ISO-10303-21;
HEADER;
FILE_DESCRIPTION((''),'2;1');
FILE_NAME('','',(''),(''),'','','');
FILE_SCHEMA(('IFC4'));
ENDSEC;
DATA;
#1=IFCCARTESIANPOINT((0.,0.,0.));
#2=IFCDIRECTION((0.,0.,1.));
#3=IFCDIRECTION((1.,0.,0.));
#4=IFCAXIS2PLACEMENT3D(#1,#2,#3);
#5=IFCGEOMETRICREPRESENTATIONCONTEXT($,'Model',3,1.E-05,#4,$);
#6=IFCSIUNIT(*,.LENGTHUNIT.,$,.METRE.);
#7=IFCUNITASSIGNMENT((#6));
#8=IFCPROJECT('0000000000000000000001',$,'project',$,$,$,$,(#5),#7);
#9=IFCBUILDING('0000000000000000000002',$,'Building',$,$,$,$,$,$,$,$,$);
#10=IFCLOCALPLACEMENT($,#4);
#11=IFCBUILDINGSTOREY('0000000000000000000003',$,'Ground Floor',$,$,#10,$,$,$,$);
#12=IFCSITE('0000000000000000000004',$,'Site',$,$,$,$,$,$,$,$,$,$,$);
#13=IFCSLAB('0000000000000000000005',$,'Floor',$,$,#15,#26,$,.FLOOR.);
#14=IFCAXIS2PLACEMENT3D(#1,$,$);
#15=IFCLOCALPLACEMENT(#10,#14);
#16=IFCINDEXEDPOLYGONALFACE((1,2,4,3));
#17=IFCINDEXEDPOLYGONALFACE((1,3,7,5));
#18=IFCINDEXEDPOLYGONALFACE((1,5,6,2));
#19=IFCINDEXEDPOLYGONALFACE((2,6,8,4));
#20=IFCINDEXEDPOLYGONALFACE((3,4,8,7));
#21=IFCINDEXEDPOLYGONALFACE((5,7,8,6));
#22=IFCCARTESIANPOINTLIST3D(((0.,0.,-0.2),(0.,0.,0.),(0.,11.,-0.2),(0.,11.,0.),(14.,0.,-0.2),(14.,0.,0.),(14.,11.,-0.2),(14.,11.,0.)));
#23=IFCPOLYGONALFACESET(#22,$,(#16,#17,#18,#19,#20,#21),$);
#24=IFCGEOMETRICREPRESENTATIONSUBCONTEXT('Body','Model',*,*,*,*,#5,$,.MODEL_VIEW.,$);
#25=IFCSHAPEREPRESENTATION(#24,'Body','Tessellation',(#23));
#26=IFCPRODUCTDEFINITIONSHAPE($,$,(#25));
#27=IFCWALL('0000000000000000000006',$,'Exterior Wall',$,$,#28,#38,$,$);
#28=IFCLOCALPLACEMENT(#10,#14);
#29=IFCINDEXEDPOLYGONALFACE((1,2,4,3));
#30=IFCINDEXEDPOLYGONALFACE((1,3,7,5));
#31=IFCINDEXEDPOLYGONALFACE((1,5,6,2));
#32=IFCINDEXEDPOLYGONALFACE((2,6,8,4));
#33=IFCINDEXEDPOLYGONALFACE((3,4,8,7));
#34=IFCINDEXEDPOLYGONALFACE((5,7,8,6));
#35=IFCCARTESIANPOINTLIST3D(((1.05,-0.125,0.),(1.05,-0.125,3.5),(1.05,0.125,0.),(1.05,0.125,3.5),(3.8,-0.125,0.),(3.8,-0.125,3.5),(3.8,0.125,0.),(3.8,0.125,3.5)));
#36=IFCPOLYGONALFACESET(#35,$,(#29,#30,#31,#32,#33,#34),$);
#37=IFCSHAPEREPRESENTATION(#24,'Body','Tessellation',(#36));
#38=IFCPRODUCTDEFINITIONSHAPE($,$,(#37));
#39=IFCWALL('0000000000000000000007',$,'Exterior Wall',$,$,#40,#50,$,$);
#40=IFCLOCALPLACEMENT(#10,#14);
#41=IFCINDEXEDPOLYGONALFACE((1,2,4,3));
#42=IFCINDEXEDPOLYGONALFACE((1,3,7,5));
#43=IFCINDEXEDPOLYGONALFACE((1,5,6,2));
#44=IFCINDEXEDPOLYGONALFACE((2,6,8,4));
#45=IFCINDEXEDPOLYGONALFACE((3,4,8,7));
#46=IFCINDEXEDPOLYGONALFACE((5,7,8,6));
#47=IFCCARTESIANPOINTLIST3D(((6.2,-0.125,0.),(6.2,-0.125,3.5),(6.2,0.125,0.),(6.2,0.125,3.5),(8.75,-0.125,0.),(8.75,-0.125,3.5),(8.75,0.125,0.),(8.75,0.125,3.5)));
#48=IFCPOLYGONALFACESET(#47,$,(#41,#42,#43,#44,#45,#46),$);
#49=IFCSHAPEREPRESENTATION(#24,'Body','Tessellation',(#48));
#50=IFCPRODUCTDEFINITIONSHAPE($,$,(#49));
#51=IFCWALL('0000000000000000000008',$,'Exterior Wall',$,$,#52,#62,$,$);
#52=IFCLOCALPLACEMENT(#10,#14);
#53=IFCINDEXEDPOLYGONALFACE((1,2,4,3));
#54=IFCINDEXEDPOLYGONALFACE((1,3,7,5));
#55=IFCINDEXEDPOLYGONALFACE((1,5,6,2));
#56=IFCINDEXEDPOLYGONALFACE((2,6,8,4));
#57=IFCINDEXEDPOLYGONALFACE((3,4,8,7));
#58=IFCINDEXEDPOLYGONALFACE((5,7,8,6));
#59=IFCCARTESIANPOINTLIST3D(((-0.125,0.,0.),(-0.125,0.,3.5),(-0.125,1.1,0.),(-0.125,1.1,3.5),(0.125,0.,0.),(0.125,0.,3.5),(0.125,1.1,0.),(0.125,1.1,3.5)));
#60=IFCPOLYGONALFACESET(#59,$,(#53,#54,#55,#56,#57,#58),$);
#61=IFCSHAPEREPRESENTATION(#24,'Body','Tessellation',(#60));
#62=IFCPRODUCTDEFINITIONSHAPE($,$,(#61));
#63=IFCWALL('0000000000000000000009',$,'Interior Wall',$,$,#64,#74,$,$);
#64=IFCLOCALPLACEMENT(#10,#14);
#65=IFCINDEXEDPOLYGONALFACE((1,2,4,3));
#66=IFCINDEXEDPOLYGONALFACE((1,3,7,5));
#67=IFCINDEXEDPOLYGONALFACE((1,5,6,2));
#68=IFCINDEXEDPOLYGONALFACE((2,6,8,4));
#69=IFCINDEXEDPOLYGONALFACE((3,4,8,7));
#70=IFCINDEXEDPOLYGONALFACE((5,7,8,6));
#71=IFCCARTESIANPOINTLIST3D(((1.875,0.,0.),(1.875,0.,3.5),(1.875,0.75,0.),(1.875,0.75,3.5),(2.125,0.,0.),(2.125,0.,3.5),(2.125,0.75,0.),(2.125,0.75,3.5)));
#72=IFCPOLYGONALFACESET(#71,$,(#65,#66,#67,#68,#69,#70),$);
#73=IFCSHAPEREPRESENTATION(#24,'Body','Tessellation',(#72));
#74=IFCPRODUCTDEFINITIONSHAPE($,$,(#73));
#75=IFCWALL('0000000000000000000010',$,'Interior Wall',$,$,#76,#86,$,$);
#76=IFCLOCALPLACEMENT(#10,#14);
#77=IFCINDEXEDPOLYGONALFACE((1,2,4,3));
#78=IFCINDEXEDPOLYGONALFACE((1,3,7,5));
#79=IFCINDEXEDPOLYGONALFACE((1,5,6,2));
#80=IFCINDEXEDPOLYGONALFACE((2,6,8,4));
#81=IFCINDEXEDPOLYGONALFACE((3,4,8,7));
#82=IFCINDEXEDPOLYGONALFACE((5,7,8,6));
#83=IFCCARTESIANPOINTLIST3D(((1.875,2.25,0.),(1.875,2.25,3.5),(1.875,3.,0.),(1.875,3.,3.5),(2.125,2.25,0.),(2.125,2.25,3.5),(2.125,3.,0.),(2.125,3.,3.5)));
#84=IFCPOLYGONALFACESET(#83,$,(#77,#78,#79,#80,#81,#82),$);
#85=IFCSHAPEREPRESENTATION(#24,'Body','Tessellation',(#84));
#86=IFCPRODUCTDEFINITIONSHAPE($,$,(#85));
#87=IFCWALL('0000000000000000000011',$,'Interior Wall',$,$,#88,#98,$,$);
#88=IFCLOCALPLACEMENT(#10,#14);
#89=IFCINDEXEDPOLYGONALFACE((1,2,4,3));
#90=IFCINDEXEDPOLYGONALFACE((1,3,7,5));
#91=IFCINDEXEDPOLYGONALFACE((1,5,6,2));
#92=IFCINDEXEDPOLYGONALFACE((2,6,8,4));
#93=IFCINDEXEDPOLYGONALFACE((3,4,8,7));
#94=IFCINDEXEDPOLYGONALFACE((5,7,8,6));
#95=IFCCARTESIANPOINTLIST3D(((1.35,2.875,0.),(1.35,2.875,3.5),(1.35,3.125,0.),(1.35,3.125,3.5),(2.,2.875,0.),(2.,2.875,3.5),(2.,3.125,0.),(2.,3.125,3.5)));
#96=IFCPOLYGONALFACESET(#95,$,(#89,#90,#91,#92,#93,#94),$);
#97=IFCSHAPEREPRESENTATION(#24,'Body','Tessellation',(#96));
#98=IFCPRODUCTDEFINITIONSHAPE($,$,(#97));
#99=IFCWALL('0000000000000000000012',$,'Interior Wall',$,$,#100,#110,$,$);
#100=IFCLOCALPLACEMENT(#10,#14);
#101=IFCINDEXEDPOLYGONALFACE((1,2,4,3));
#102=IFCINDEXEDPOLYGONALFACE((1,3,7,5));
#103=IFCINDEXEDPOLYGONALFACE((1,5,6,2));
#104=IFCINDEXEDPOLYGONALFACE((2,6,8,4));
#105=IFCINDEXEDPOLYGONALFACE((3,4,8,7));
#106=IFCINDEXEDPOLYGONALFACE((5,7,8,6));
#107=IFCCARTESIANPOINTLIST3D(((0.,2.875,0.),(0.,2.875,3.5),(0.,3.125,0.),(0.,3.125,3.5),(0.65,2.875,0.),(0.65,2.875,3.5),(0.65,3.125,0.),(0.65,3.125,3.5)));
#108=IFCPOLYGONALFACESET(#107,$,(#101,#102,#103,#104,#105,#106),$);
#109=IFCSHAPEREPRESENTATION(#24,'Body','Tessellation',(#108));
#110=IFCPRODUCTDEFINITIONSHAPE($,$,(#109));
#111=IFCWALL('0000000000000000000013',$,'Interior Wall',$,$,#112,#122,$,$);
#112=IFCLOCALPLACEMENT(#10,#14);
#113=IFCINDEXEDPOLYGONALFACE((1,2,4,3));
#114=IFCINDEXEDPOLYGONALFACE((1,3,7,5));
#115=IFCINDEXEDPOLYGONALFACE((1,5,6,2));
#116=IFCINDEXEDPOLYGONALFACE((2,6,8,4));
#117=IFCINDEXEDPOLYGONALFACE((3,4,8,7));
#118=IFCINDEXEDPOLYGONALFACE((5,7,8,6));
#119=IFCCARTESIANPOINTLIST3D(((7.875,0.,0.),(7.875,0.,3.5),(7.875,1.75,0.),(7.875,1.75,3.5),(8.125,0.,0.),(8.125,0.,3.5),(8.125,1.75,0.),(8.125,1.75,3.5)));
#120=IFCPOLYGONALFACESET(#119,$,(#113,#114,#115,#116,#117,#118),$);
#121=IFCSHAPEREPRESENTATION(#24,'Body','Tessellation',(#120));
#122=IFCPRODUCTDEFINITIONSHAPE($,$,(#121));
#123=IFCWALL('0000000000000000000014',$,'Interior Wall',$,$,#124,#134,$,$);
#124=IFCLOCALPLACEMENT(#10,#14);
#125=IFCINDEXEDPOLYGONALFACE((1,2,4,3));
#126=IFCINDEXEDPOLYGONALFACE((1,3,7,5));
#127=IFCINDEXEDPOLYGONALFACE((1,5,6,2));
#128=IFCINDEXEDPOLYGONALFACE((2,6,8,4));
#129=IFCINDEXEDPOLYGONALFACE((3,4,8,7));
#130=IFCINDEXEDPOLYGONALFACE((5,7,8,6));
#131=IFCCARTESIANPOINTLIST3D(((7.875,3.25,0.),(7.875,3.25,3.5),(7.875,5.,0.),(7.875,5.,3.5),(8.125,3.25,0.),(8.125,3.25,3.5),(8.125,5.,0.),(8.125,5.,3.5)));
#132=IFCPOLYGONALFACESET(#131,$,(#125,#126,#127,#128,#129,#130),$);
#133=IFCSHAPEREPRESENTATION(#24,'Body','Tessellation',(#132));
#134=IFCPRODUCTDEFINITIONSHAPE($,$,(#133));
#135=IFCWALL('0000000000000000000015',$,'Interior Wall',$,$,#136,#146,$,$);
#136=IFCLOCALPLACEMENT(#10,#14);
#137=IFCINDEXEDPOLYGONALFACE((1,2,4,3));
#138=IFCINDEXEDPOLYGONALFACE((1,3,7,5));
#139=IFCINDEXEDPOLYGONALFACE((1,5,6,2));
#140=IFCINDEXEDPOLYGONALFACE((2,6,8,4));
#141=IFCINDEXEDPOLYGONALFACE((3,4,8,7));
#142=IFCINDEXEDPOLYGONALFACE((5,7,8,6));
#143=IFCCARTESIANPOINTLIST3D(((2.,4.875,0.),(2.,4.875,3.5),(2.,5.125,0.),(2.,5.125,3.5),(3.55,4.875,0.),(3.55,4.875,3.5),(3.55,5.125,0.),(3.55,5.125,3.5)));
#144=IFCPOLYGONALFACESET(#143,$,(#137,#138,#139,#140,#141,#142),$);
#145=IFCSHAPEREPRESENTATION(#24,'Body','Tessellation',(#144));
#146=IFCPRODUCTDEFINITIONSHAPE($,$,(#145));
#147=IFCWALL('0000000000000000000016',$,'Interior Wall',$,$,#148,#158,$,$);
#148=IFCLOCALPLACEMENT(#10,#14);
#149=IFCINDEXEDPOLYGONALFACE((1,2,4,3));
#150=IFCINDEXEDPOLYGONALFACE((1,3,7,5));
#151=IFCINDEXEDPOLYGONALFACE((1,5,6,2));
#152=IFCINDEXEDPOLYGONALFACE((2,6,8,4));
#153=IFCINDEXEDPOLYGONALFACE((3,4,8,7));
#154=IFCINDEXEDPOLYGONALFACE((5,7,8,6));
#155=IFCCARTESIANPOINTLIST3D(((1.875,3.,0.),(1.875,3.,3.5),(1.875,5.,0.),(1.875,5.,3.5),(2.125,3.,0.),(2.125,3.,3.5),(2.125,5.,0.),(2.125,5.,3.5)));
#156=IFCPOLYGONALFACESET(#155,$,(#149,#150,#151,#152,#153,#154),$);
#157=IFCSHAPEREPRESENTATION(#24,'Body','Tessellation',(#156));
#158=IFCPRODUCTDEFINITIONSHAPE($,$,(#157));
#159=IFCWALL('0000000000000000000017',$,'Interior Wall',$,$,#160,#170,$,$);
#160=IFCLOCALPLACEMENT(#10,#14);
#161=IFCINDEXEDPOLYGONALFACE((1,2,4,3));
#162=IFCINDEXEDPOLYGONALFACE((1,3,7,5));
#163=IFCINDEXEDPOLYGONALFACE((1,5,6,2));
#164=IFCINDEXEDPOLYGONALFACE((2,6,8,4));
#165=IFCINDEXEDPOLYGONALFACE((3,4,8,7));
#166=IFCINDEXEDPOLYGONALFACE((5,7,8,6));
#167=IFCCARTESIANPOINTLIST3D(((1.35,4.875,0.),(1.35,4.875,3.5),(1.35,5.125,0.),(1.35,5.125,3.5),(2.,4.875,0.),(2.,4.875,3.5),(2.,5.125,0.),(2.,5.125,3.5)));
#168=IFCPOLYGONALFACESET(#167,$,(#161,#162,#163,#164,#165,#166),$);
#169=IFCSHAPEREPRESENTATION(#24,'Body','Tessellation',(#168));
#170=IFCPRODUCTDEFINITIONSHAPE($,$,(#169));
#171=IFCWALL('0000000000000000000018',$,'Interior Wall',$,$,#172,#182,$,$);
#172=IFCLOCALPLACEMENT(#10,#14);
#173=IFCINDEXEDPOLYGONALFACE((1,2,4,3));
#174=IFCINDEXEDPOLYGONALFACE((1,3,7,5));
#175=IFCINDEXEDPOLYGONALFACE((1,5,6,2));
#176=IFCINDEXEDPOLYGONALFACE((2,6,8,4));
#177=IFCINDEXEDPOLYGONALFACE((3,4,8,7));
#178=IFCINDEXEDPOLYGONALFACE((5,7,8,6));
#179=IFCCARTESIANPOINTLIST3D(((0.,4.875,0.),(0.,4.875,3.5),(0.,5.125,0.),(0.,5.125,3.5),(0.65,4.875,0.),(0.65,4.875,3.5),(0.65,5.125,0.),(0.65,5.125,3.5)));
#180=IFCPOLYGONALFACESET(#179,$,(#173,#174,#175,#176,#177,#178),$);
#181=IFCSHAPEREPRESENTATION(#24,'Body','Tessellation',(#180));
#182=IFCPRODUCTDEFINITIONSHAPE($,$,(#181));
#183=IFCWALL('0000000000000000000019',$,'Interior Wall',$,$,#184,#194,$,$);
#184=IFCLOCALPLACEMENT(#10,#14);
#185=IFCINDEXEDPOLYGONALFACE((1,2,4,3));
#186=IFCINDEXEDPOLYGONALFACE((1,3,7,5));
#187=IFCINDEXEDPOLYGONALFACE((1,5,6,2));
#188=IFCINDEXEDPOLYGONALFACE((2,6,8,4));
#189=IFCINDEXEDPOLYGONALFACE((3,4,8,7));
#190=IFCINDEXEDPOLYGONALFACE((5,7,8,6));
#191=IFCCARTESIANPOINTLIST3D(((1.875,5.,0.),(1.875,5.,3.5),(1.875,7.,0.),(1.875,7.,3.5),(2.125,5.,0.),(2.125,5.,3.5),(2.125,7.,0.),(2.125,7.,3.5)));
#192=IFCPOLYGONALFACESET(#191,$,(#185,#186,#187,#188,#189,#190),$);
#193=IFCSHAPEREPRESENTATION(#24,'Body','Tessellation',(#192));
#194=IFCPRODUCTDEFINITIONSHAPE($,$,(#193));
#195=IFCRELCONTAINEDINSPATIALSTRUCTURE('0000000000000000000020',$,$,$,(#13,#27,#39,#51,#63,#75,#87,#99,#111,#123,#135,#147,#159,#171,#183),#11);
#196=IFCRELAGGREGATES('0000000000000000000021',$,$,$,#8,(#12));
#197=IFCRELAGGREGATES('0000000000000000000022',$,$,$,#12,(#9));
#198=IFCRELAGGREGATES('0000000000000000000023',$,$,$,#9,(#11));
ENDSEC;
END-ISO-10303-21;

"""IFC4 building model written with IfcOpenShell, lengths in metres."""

from ifc_helpers import new_model, si_unit, frame, origin_with_axes, place, context, subcontext, project, spatial, indexed_curve, outline, extrude, element, save


model = new_model("IFC4")

# Units and contexts
model_context = context("Model", 3, precision=1e-05, world=origin_with_axes())
body_context = subcontext(model_context, "Body", "Model", "MODEL_VIEW")
ifc_project = project(units=[si_unit("LENGTHUNIT", "METRE")], contexts=[model_context])

# Site, building, storey
site = spatial("IfcSite", under=ifc_project, Name="Site")
building = spatial("IfcBuilding", under=site, Name="Building")
storey_placement = place(None, origin_with_axes())
storey = spatial("IfcBuildingStorey", under=building, at=storey_placement, Name="Ground Floor")

# Slab
slab_placement = place(storey_placement, frame((0.0, 0.0, -0.2), z_axis=(0.0, 0.0, 1.0), x_axis=(1.0, 0.0, 0.0)))
element("IfcSlab", 1, at=slab_placement, inside=storey, Name="Floor", PredefinedType="FLOOR", context=body_context, shape_type="SweptSolid", body=[
    extrude(outline(indexed_curve([(0.0, 0.0), (14.0, 0.0), (14.0, 11.0), (0.0, 11.0)])), None, (0.0, 0.0, 1.0), 0.2),
])

# Walls
wall_1_placement = place(storey_placement, frame((1.05, 0.0, 0.0), z_axis=(0.0, 0.0, 1.0), x_axis=(1.0, 0.0, 0.0)))
element("IfcWall", 2, at=wall_1_placement, inside=storey, Name="Exterior Wall", context=body_context, shape_type="SweptSolid", body=[
    extrude(outline(indexed_curve([(0.0, 0.0), (0.0, 0.25), (2.75, 0.25), (2.75, 0.0), (0.0, 0.0)], self_intersect=False)), frame((0.0, -0.125, 0.0), z_axis=(0.0, 0.0, 1.0), x_axis=(1.0, 0.0, 0.0)), (0.0, 0.0, 1.0), 3.5),
])
wall_2_placement = place(storey_placement, frame((6.2, 0.0, 0.0), z_axis=(0.0, 0.0, 1.0), x_axis=(1.0, 0.0, 0.0)))
element("IfcWall", 3, at=wall_2_placement, inside=storey, Name="Exterior Wall", context=body_context, shape_type="SweptSolid", body=[
    extrude(outline(indexed_curve([(0.0, 0.0), (0.0, 0.25), (2.55, 0.25), (2.55, 0.0), (0.0, 0.0)], self_intersect=False)), frame((0.0, -0.125, 0.0), z_axis=(0.0, 0.0, 1.0), x_axis=(1.0, 0.0, 0.0)), (0.0, 0.0, 1.0), 3.5),
])
wall_3_placement = place(storey_placement, frame((0.0, 1.1, 0.0), z_axis=(0.0, 0.0, 1.0), x_axis=(0.0, -1.0, 0.0)))
element("IfcWall", 4, at=wall_3_placement, inside=storey, Name="Exterior Wall", context=body_context, shape_type="SweptSolid", body=[
    extrude(outline(indexed_curve([(0.0, 0.0), (0.0, 0.25), (1.1, 0.25), (1.1, 0.0), (0.0, 0.0)], self_intersect=False)), frame((0.0, -0.125, 0.0), z_axis=(0.0, 0.0, 1.0), x_axis=(1.0, 0.0, 0.0)), (0.0, 0.0, 1.0), 3.5),
])
for number, where, z_axis, x_axis, name in (
    (5, (2.0, 0.0, 0.0), (0.0, 0.0, 1.0), (0.0, 1.0, 0.0), "Interior Wall"),
    (6, (2.0, 2.25, 0.0), (0.0, 0.0, 1.0), (0.0, 1.0, 0.0), "Interior Wall"),
):
    element("IfcWall", number, at=place(storey_placement, frame(where, z_axis=z_axis, x_axis=x_axis)), inside=storey, Name=name, context=body_context, shape_type="SweptSolid", body=[
        extrude(outline(indexed_curve([(0.0, 0.0), (0.0, 0.25), (0.75, 0.25), (0.75, 0.0), (0.0, 0.0)], self_intersect=False)), frame((0.0, -0.125, 0.0), z_axis=(0.0, 0.0, 1.0), x_axis=(1.0, 0.0, 0.0)), (0.0, 0.0, 1.0), 3.5),
    ])
for number, where, z_axis, x_axis, name in (
    (7, (2.0, 3.0, 0.0), (0.0, 0.0, 1.0), (-1.0, 0.0, 0.0), "Interior Wall"),
    (8, (0.65, 3.0, 0.0), (0.0, 0.0, 1.0), (-1.0, 0.0, 0.0), "Interior Wall"),
):
    element("IfcWall", number, at=place(storey_placement, frame(where, z_axis=z_axis, x_axis=x_axis)), inside=storey, Name=name, context=body_context, shape_type="SweptSolid", body=[
        extrude(outline(indexed_curve([(0.0, 0.0), (0.0, 0.25), (0.65, 0.25), (0.65, 0.0), (0.0, 0.0)], self_intersect=False)), frame((0.0, -0.125, 0.0), z_axis=(0.0, 0.0, 1.0), x_axis=(1.0, 0.0, 0.0)), (0.0, 0.0, 1.0), 3.5),
    ])
for number, where, z_axis, x_axis, name in (
    (9, (8.0, 0.0, 0.0), (0.0, 0.0, 1.0), (0.0, 1.0, 0.0), "Interior Wall"),
    (10, (8.0, 3.25, 0.0), (0.0, 0.0, 1.0), (0.0, 1.0, 0.0), "Interior Wall"),
):
    element("IfcWall", number, at=place(storey_placement, frame(where, z_axis=z_axis, x_axis=x_axis)), inside=storey, Name=name, context=body_context, shape_type="SweptSolid", body=[
        extrude(outline(indexed_curve([(0.0, 0.0), (0.0, 0.25), (1.75, 0.25), (1.75, 0.0), (0.0, 0.0)], self_intersect=False)), frame((0.0, -0.125, 0.0), z_axis=(0.0, 0.0, 1.0), x_axis=(1.0, 0.0, 0.0)), (0.0, 0.0, 1.0), 3.5),
    ])
wall_4_placement = place(storey_placement, frame((3.55, 5.0, 0.0), z_axis=(0.0, 0.0, 1.0), x_axis=(-1.0, 0.0, 0.0)))
element("IfcWall", 11, at=wall_4_placement, inside=storey, Name="Interior Wall", context=body_context, shape_type="SweptSolid", body=[
    extrude(outline(indexed_curve([(0.0, 0.0), (0.0, 0.25), (1.55, 0.25), (1.55, 0.0), (0.0, 0.0)], self_intersect=False)), frame((0.0, -0.125, 0.0), z_axis=(0.0, 0.0, 1.0), x_axis=(1.0, 0.0, 0.0)), (0.0, 0.0, 1.0), 3.5),
])
wall_5_placement = place(storey_placement, frame((2.0, 5.0, 0.0), z_axis=(0.0, 0.0, 1.0), x_axis=(0.0, -1.0, 0.0)))
element("IfcWall", 12, at=wall_5_placement, inside=storey, Name="Interior Wall", context=body_context, shape_type="SweptSolid", body=[
    extrude(outline(indexed_curve([(0.0, 0.0), (0.0, 0.25), (2.0, 0.25), (2.0, 0.0), (0.0, 0.0)], self_intersect=False)), frame((0.0, -0.125, 0.0), z_axis=(0.0, 0.0, 1.0), x_axis=(1.0, 0.0, 0.0)), (0.0, 0.0, 1.0), 3.5),
])
for number, where, z_axis, x_axis, name in (
    (13, (2.0, 5.0, 0.0), (0.0, 0.0, 1.0), (-1.0, 0.0, 0.0), "Interior Wall"),
    (14, (0.65, 5.0, 0.0), (0.0, 0.0, 1.0), (-1.0, 0.0, 0.0), "Interior Wall"),
):
    element("IfcWall", number, at=place(storey_placement, frame(where, z_axis=z_axis, x_axis=x_axis)), inside=storey, Name=name, context=body_context, shape_type="SweptSolid", body=[
        extrude(outline(indexed_curve([(0.0, 0.0), (0.0, 0.25), (0.65, 0.25), (0.65, 0.0), (0.0, 0.0)], self_intersect=False)), frame((0.0, -0.125, 0.0), z_axis=(0.0, 0.0, 1.0), x_axis=(1.0, 0.0, 0.0)), (0.0, 0.0, 1.0), 3.5),
    ])
wall_6_placement = place(storey_placement, frame((2.0, 5.0, 0.0), z_axis=(0.0, 0.0, 1.0), x_axis=(0.0, 1.0, 0.0)))
element("IfcWall", 15, at=wall_6_placement, inside=storey, Name="Interior Wall", context=body_context, shape_type="SweptSolid", body=[
    extrude(outline(indexed_curve([(0.0, 0.0), (0.0, 0.25), (2.0, 0.25), (2.0, 0.0), (0.0, 0.0)], self_intersect=False)), frame((0.0, -0.125, 0.0), z_axis=(0.0, 0.0, 1.0), x_axis=(1.0, 0.0, 0.0)), (0.0, 0.0, 1.0), 3.5),
])

save(model, "model.ifc")
